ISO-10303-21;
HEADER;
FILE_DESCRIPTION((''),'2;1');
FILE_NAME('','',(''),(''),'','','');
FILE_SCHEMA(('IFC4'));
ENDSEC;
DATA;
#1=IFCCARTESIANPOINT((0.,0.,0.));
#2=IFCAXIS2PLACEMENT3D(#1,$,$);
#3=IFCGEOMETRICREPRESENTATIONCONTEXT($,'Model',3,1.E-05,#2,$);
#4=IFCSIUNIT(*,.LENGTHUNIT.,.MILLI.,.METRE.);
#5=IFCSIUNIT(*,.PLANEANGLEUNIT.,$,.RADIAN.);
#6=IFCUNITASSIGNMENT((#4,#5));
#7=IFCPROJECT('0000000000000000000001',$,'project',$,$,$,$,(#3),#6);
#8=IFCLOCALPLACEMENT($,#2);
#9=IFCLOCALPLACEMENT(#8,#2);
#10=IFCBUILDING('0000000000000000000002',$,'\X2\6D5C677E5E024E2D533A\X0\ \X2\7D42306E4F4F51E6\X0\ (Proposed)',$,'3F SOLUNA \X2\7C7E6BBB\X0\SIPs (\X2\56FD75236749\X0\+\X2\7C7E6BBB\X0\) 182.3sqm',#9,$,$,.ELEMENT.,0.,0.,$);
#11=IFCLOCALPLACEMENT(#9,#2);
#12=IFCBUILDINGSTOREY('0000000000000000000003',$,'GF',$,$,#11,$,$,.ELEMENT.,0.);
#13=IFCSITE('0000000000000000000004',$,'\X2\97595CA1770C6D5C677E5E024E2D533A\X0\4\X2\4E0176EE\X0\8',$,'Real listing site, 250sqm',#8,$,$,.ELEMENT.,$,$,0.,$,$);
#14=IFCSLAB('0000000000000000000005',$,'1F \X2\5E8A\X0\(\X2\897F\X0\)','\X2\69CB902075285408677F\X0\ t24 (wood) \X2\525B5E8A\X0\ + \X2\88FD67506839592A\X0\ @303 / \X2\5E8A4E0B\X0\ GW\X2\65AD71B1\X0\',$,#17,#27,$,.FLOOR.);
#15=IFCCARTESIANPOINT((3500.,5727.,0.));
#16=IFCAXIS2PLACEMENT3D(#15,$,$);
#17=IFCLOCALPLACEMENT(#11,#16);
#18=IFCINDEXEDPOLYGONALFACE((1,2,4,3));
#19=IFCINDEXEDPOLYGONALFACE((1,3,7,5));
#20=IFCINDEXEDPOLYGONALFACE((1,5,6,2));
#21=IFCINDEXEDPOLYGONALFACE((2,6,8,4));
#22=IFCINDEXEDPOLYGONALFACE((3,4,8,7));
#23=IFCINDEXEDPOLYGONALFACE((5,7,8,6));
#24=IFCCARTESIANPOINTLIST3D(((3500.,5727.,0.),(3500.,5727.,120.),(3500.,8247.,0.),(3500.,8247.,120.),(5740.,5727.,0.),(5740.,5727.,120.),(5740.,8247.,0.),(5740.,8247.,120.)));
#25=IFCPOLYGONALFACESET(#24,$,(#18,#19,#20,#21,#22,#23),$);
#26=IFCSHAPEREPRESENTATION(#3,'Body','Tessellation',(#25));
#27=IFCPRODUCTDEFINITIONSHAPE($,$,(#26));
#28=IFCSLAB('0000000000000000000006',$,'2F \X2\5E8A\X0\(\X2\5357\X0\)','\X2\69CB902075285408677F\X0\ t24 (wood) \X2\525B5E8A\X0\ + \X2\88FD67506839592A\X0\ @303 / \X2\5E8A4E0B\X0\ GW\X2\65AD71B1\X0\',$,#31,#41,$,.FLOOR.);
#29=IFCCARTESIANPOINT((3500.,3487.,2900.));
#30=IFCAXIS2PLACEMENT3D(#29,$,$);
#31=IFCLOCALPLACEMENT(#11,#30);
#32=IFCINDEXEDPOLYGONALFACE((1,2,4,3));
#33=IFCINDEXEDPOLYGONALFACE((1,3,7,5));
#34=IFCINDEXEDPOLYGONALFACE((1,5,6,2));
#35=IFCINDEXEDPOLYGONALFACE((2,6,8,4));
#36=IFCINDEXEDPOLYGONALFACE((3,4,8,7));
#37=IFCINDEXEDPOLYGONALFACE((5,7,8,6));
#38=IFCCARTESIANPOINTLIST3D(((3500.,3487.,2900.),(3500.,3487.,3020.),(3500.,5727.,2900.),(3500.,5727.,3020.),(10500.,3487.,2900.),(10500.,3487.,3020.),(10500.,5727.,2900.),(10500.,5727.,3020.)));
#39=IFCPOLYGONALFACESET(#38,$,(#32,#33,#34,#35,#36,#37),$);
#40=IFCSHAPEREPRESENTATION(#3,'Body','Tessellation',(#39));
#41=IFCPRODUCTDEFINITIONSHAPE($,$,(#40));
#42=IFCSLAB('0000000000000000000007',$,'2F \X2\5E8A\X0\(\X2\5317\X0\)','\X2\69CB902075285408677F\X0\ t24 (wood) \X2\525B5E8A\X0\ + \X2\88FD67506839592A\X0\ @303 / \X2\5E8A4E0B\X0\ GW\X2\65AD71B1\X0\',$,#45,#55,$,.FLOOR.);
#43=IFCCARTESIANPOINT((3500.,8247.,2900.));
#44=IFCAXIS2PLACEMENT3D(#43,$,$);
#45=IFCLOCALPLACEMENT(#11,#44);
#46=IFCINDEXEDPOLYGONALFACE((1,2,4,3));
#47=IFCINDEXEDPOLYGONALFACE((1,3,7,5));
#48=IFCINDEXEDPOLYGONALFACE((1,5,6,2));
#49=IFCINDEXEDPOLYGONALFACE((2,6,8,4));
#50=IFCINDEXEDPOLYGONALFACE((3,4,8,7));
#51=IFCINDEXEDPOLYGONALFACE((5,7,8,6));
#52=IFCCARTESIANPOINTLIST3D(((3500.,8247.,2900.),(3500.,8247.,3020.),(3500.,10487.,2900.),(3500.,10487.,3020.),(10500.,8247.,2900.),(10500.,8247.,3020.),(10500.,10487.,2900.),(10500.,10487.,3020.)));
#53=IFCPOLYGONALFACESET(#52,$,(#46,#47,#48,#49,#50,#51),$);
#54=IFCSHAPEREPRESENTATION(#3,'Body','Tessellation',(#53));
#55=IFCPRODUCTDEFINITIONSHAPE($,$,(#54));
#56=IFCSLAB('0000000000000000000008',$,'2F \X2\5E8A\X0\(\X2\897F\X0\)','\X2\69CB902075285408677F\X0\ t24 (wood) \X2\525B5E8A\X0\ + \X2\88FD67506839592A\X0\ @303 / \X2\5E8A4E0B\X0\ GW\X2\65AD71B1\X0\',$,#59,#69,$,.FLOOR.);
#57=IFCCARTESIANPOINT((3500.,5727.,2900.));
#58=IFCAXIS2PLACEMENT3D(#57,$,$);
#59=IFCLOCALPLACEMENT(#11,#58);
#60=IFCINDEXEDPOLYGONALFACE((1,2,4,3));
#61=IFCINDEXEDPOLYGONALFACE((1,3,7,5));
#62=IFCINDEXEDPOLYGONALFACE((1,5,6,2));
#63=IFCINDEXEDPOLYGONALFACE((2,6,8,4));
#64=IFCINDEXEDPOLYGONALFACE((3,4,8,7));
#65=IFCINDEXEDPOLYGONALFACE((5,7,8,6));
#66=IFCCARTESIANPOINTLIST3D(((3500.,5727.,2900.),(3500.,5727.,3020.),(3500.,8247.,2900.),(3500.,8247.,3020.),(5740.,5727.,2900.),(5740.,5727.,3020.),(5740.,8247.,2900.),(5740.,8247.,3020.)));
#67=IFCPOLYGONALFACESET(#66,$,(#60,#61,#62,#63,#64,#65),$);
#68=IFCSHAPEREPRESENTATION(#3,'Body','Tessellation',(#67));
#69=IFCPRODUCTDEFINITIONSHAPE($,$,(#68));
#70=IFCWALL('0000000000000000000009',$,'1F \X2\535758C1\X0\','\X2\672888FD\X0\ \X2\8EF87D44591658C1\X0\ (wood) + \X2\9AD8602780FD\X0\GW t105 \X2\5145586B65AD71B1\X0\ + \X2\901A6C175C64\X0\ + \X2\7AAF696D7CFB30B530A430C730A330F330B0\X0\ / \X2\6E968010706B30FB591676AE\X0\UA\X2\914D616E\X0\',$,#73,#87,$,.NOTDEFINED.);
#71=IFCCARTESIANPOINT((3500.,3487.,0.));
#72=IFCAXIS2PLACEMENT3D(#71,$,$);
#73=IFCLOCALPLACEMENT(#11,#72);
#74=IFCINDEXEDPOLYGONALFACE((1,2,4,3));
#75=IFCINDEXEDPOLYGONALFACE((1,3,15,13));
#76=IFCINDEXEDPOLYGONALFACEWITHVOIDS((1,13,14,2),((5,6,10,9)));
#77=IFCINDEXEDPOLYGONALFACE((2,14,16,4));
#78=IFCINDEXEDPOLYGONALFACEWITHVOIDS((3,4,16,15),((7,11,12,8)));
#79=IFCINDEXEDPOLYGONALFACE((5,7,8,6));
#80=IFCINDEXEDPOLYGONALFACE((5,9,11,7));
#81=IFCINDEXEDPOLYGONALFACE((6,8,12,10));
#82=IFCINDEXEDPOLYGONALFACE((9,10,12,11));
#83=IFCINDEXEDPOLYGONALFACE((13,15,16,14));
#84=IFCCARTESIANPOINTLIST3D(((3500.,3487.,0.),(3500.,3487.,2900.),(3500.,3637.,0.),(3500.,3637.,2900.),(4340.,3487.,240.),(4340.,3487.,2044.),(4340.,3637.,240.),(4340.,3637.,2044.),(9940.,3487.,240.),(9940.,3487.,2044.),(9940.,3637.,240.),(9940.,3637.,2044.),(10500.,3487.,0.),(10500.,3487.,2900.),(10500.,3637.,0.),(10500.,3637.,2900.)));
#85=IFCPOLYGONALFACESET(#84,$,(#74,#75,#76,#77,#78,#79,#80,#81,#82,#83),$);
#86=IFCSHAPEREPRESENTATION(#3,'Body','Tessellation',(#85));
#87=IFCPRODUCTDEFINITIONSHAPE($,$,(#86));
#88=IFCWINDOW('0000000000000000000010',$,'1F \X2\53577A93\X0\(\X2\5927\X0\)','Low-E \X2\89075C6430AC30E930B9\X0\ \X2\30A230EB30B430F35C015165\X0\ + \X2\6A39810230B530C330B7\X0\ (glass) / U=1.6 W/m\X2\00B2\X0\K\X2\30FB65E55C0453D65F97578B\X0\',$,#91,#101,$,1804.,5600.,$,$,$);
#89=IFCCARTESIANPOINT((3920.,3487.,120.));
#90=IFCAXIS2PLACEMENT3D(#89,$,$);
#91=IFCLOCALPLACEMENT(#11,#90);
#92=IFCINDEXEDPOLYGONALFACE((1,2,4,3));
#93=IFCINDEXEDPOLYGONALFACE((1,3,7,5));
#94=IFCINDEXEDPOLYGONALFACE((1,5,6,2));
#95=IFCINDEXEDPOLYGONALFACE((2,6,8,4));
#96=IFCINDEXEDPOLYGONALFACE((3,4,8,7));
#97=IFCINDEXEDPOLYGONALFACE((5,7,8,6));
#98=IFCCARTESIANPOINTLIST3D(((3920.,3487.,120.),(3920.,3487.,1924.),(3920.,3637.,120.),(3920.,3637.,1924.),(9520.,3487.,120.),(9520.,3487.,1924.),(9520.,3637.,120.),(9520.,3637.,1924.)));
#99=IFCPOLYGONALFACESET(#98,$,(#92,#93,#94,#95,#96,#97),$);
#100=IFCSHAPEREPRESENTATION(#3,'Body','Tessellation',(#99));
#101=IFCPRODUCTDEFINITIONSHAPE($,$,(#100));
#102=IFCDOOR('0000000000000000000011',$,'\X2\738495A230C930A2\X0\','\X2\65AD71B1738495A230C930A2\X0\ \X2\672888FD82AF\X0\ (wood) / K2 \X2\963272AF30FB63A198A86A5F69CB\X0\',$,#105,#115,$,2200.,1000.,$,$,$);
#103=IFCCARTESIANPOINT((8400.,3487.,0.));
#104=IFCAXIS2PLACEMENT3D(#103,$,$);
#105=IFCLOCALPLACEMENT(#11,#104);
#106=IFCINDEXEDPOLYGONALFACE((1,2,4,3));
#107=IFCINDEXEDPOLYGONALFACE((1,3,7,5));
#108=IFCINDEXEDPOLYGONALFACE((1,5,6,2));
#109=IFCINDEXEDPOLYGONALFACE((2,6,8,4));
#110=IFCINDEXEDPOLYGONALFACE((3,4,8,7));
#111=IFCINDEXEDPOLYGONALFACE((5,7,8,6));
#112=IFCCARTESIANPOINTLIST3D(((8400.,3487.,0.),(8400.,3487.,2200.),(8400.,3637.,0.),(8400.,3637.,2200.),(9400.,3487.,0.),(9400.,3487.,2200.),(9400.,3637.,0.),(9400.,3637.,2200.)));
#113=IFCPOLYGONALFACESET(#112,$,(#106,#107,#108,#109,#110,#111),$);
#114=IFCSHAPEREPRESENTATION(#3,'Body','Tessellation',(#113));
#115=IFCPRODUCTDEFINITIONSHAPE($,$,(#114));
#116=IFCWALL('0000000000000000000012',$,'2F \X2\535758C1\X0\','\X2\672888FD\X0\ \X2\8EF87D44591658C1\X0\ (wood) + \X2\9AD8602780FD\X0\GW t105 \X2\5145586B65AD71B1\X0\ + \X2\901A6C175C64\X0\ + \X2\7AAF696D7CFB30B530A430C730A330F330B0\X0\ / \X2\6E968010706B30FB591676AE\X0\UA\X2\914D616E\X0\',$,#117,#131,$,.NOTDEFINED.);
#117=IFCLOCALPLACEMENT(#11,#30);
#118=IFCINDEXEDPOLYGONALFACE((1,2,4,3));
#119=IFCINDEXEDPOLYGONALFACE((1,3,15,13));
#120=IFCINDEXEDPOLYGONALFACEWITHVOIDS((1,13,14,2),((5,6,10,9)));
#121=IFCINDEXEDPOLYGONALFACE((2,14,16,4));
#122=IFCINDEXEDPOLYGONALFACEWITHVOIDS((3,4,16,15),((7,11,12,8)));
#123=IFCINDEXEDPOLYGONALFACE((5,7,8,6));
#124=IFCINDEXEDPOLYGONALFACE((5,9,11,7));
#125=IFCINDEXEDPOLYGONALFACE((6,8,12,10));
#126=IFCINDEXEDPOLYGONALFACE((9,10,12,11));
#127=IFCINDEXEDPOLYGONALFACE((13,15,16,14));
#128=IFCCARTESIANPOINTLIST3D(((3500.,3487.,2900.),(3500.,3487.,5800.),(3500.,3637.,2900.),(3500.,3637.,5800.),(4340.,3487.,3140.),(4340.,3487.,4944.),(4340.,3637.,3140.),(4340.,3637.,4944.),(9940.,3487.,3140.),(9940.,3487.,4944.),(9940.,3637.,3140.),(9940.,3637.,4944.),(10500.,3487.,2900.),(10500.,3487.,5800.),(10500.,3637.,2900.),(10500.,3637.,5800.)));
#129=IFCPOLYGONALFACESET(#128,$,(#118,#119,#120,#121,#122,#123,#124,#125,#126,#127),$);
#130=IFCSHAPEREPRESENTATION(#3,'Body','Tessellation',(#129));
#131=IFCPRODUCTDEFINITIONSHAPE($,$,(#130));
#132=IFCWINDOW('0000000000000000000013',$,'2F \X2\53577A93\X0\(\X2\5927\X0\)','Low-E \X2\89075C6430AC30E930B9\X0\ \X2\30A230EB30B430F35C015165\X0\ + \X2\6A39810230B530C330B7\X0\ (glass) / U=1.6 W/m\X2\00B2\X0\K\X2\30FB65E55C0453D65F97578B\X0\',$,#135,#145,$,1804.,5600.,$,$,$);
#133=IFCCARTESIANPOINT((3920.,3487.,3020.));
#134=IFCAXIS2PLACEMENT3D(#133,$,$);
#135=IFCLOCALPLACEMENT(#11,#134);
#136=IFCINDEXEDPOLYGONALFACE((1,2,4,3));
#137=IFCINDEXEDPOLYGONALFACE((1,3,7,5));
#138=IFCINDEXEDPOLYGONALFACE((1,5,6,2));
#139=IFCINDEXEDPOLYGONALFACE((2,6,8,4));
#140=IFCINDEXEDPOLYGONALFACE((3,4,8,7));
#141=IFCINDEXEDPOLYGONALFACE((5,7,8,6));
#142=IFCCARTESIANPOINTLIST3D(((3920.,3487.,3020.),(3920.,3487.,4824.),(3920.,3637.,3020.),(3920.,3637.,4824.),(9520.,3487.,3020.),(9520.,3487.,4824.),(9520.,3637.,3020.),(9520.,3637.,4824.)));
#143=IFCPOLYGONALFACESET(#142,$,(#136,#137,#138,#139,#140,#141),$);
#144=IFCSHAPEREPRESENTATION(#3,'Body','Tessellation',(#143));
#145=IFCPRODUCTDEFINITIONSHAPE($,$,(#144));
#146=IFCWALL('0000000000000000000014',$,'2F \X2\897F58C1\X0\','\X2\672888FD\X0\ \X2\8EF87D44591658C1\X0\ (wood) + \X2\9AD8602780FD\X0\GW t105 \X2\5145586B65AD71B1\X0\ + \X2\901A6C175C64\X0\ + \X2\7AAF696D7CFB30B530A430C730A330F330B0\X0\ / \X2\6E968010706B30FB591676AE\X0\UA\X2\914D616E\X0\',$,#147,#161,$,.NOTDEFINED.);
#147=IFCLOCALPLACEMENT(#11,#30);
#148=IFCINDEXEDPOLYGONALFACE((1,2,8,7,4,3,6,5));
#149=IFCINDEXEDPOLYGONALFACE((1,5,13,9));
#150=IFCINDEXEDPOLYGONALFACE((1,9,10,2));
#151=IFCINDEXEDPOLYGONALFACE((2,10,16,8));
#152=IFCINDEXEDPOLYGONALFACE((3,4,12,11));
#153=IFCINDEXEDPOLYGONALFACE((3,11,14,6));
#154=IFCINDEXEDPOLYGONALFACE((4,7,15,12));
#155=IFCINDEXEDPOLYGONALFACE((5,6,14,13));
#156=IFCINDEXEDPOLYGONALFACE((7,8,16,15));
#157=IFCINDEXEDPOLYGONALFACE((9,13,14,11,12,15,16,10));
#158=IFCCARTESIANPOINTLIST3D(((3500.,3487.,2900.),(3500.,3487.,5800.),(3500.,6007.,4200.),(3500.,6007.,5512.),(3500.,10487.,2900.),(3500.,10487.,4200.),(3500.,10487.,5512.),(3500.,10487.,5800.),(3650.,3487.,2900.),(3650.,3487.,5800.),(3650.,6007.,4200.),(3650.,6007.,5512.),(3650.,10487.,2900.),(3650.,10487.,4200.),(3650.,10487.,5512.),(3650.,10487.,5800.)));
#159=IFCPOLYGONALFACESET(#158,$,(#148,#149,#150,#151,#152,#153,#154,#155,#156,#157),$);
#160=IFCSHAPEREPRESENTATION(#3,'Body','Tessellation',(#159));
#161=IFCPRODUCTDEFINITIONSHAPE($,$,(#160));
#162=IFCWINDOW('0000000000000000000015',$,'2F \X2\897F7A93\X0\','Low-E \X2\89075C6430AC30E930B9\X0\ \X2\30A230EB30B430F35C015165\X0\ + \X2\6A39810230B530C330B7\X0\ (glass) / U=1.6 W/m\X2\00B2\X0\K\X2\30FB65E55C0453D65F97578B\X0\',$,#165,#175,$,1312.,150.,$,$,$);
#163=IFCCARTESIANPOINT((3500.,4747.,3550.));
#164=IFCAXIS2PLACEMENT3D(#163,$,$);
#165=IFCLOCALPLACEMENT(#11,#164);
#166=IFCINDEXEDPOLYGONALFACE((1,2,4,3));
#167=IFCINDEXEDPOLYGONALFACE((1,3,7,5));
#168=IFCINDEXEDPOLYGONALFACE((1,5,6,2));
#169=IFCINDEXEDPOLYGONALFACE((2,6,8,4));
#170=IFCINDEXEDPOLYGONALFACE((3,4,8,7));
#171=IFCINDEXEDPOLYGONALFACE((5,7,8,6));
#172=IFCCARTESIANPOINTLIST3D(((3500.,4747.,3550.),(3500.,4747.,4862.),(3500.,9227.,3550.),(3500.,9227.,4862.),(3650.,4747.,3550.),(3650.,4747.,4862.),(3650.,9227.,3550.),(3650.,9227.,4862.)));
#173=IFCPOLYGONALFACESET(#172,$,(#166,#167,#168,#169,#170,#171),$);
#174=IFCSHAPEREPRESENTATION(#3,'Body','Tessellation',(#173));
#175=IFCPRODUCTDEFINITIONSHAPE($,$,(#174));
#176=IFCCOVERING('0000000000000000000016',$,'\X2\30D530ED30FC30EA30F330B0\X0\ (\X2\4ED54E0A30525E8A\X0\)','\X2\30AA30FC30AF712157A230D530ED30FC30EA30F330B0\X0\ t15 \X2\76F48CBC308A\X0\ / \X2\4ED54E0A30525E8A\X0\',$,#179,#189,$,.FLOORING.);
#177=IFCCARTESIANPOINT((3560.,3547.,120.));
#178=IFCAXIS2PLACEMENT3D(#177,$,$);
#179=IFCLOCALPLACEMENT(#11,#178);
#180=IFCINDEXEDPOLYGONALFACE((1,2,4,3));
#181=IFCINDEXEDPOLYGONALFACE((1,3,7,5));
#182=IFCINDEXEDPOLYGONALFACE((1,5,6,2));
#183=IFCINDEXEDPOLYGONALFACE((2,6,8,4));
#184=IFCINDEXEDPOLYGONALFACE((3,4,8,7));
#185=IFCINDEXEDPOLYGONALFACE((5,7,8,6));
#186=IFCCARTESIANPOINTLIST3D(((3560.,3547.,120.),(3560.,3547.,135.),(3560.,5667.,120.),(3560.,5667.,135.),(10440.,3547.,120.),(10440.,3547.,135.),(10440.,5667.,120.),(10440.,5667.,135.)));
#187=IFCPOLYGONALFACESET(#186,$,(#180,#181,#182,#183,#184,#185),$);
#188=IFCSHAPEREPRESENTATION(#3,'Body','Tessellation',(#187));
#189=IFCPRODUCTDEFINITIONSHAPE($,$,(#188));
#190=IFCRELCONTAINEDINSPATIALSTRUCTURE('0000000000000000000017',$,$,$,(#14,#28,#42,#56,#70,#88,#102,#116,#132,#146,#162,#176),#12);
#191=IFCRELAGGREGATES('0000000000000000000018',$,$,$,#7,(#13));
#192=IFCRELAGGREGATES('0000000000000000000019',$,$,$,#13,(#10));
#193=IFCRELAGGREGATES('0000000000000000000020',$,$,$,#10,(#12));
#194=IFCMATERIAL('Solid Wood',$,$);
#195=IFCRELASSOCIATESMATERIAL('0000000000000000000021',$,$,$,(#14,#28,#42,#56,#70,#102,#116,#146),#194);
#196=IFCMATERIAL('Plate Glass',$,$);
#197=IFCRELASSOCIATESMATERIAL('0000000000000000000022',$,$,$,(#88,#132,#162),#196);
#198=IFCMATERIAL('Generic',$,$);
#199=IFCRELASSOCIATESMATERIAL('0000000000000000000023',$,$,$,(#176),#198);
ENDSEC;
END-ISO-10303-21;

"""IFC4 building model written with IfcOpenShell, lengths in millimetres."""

from ifc_helpers import new_model, si_unit, frame, frame_2d, origin, place, context, project, spatial, rectangle, extrude, material, element, fill, save


model = new_model("IFC4")

# Units and contexts
model_context = context("Model", 3, precision=1e-05, world=origin())
ifc_project = project(units=[si_unit("LENGTHUNIT", "METRE", prefix="MILLI"), si_unit("PLANEANGLEUNIT", "RADIAN")], contexts=[model_context])

# Site, building, storey
site_placement = place(None, origin())
site = spatial("IfcSite", under=ifc_project, at=site_placement, Name="静岡県浜松市中区4丁目8", ObjectType="Real listing site, 250sqm", CompositionType="ELEMENT", RefElevation=0.0)
building_placement = place(site_placement, origin())
building = spatial("IfcBuilding", under=site, at=building_placement, Name="浜松市中区 終の住処 (Proposed)", ObjectType="3F SOLUNA 籾殻SIPs (国産杉+籾殻) 182.3sqm", CompositionType="ELEMENT", ElevationOfRefHeight=0.0, ElevationOfTerrain=0.0)
storey_placement = place(building_placement, origin())
storey = spatial("IfcBuildingStorey", under=building, at=storey_placement, Name="GF", CompositionType="ELEMENT", Elevation=0.0)

# Slabs
ifc_material_1 = material(Name="Solid Wood")
slab_1_placement = place(storey_placement, frame((3500.0, 5727.0, 0.0)))
element("IfcSlab", 1, at=slab_1_placement, inside=storey, material=ifc_material_1, Name="1F 床(西)", Description="構造用合板 t24 (wood) 剛床 + 製材根太 @303 / 床下 GW断熱", PredefinedType="FLOOR", context=model_context, shape_type="SweptSolid", body=[
    extrude(rectangle(XDim=2240.0, YDim=2520.0, at=frame_2d((1120.0, 1260.0))), frame((3500.0, 5727.0, 0.0)), (0.0, 0.0, 1.0), 120.0),
])
slab_2_placement = place(storey_placement, frame((3500.0, 3487.0, 2900.0)))
element("IfcSlab", 2, at=slab_2_placement, inside=storey, material=ifc_material_1, Name="2F 床(南)", Description="構造用合板 t24 (wood) 剛床 + 製材根太 @303 / 床下 GW断熱", PredefinedType="FLOOR", context=model_context, shape_type="SweptSolid", body=[
    extrude(rectangle(XDim=7000.0, YDim=2240.0, at=frame_2d((3500.0, 1120.0))), frame((3500.0, 3487.0, 2900.0)), (0.0, 0.0, 1.0), 120.0),
])
slab_3_placement = place(storey_placement, frame((3500.0, 8247.0, 2900.0)))
element("IfcSlab", 3, at=slab_3_placement, inside=storey, material=ifc_material_1, Name="2F 床(北)", Description="構造用合板 t24 (wood) 剛床 + 製材根太 @303 / 床下 GW断熱", PredefinedType="FLOOR", context=model_context, shape_type="SweptSolid", body=[
    extrude(rectangle(XDim=7000.0, YDim=2240.0, at=frame_2d((3500.0, 1120.0))), frame((3500.0, 8247.0, 2900.0)), (0.0, 0.0, 1.0), 120.0),
])
slab_4_placement = place(storey_placement, frame((3500.0, 5727.0, 2900.0)))
element("IfcSlab", 4, at=slab_4_placement, inside=storey, material=ifc_material_1, Name="2F 床(西)", Description="構造用合板 t24 (wood) 剛床 + 製材根太 @303 / 床下 GW断熱", PredefinedType="FLOOR", context=model_context, shape_type="SweptSolid", body=[
    extrude(rectangle(XDim=2240.0, YDim=2520.0, at=frame_2d((1120.0, 1260.0))), frame((3500.0, 5727.0, 2900.0)), (0.0, 0.0, 1.0), 120.0),
])

# Wall, openings, window, door
wall_1_placement = place(storey_placement, frame((3500.0, 3487.0, 0.0)))
wall_1 = element("IfcWall", 5, at=wall_1_placement, inside=storey, material=ifc_material_1, Name="1F 南壁", Description="木製 軸組外壁 (wood) + 高性能GW t105 充填断熱 + 通気層 + 窯業系サイディング / 準耐火・外皮UA配慮", PredefinedType="NOTDEFINED", context=model_context, shape_type="SweptSolid", body=[
    extrude(rectangle(XDim=7000.0, YDim=150.0, at=frame_2d((3500.0, 75.0))), frame((3500.0, 3487.0, 0.0)), (0.0, 0.0, 1.0), 2900.0),
])
opening_1_placement = place(storey_placement, frame((3920.0, 3487.0, 120.0)))
opening_1 = element("IfcOpeningElement", 6, at=opening_1_placement, cuts=wall_1, PredefinedType="NOTDEFINED", context=model_context, shape_type="SweptSolid", body=[
    extrude(rectangle(XDim=5600.0, YDim=150.0, at=frame_2d((2800.0, 75.0))), frame((3920.0, 3487.0, 120.0)), (0.0, 0.0, 1.0), 1804.0),
])
opening_2_placement = place(storey_placement, frame((8400.0, 3487.0, 0.0)))
opening_2 = element("IfcOpeningElement", 7, at=opening_2_placement, cuts=wall_1, PredefinedType="NOTDEFINED", context=model_context, shape_type="SweptSolid", body=[
    extrude(rectangle(XDim=1000.0, YDim=150.0, at=frame_2d((500.0, 75.0))), frame((8400.0, 3487.0, 0.0)), (0.0, 0.0, 1.0), 2200.0),
])
ifc_material_2 = material(Name="Plate Glass")
window_1_placement = place(storey_placement, frame((3920.0, 3487.0, 120.0)))
window_1 = element("IfcWindow", 8, at=window_1_placement, inside=storey, material=ifc_material_2, Name="1F 南窓(大)", Description="Low-E 複層ガラス アルゴン封入 + 樹脂サッシ (glass) / U=1.6 W/m²K・日射取得型", OverallHeight=1804.0, OverallWidth=5600.0, context=model_context, shape_type="SweptSolid", body=[
    extrude(rectangle(XDim=5600.0, YDim=150.0, at=frame_2d((2800.0, 75.0))), frame((3920.0, 3487.0, 120.0)), (0.0, 0.0, 1.0), 1804.0),
])
fill(opening_1, window_1)
door_placement = place(storey_placement, frame((8400.0, 3487.0, 0.0)))
door = element("IfcDoor", 9, at=door_placement, inside=storey, material=ifc_material_1, Name="玄関ドア", Description="断熱玄関ドア 木製芯 (wood) / K2 防犯・採風機構", OverallHeight=2200.0, OverallWidth=1000.0, context=model_context, shape_type="SweptSolid", body=[
    extrude(rectangle(XDim=1000.0, YDim=150.0, at=frame_2d((500.0, 75.0))), frame((8400.0, 3487.0, 0.0)), (0.0, 0.0, 1.0), 2200.0),
])
fill(opening_2, door)

# Wall, opening, window
wall_2_placement = place(storey_placement, frame((3500.0, 3487.0, 2900.0)))
wall_2 = element("IfcWall", 10, at=wall_2_placement, inside=storey, material=ifc_material_1, Name="2F 南壁", Description="木製 軸組外壁 (wood) + 高性能GW t105 充填断熱 + 通気層 + 窯業系サイディング / 準耐火・外皮UA配慮", PredefinedType="NOTDEFINED", context=model_context, shape_type="SweptSolid", body=[
    extrude(rectangle(XDim=7000.0, YDim=150.0, at=frame_2d((3500.0, 75.0))), frame((3500.0, 3487.0, 2900.0)), (0.0, 0.0, 1.0), 2900.0),
])
opening_3_placement = place(storey_placement, frame((3920.0, 3487.0, 3020.0)))
opening_3 = element("IfcOpeningElement", 11, at=opening_3_placement, cuts=wall_2, PredefinedType="NOTDEFINED", context=model_context, shape_type="SweptSolid", body=[
    extrude(rectangle(XDim=5600.0, YDim=150.0, at=frame_2d((2800.0, 75.0))), frame((3920.0, 3487.0, 3020.0)), (0.0, 0.0, 1.0), 1804.0),
])
window_2_placement = place(storey_placement, frame((3920.0, 3487.0, 3020.0)))
window_2 = element("IfcWindow", 12, at=window_2_placement, inside=storey, material=ifc_material_2, Name="2F 南窓(大)", Description="Low-E 複層ガラス アルゴン封入 + 樹脂サッシ (glass) / U=1.6 W/m²K・日射取得型", OverallHeight=1804.0, OverallWidth=5600.0, context=model_context, shape_type="SweptSolid", body=[
    extrude(rectangle(XDim=5600.0, YDim=150.0, at=frame_2d((2800.0, 75.0))), frame((3920.0, 3487.0, 3020.0)), (0.0, 0.0, 1.0), 1804.0),
])
fill(opening_3, window_2)

# Wall, opening, window
wall_3_placement = place(storey_placement, frame((3500.0, 3487.0, 2900.0)))
wall_3 = element("IfcWall", 13, at=wall_3_placement, inside=storey, material=ifc_material_1, Name="2F 西壁", Description="木製 軸組外壁 (wood) + 高性能GW t105 充填断熱 + 通気層 + 窯業系サイディング / 準耐火・外皮UA配慮", PredefinedType="NOTDEFINED", context=model_context, shape_type="SweptSolid", body=[
    extrude(rectangle(XDim=150.0, YDim=7000.0, at=frame_2d((75.0, 3500.0))), frame((3500.0, 3487.0, 2900.0)), (0.0, 0.0, 1.0), 2900.0),
])
opening_4_placement = place(storey_placement, frame((3500.0, 4747.0, 3550.0)))
opening_4 = element("IfcOpeningElement", 14, at=opening_4_placement, cuts=wall_3, PredefinedType="NOTDEFINED", context=model_context, shape_type="SweptSolid", body=[
    extrude(rectangle(XDim=150.0, YDim=4480.0, at=frame_2d((75.0, 2240.0))), frame((3500.0, 4747.0, 3550.0)), (0.0, 0.0, 1.0), 1312.0),
])
window_3_placement = place(storey_placement, frame((3500.0, 4747.0, 3550.0)))
window_3 = element("IfcWindow", 15, at=window_3_placement, inside=storey, material=ifc_material_2, Name="2F 西窓", Description="Low-E 複層ガラス アルゴン封入 + 樹脂サッシ (glass) / U=1.6 W/m²K・日射取得型", OverallHeight=1312.0, OverallWidth=150.0, context=model_context, shape_type="SweptSolid", body=[
    extrude(rectangle(XDim=150.0, YDim=4480.0, at=frame_2d((75.0, 2240.0))), frame((3500.0, 4747.0, 3550.0)), (0.0, 0.0, 1.0), 1312.0),
])
fill(opening_4, window_3)

# Covering
ifc_material_3 = material(Name="Generic")
covering_1_placement = place(storey_placement, frame((3560.0, 3547.0, 120.0)))
element("IfcCovering", 16, at=covering_1_placement, inside=storey, material=ifc_material_3, Name="フローリング (仕上げ床)", Description="オーク無垢フローリング t15 直貼り / 仕上げ床", PredefinedType="FLOORING", context=model_context, shape_type="SweptSolid", body=[
    extrude(rectangle(XDim=6880.0, YDim=2120.0, at=frame_2d((3440.0, 1060.0))), frame((3560.0, 3547.0, 120.0)), (0.0, 0.0, 1.0), 15.0),
])

save(model, "model.ifc")
